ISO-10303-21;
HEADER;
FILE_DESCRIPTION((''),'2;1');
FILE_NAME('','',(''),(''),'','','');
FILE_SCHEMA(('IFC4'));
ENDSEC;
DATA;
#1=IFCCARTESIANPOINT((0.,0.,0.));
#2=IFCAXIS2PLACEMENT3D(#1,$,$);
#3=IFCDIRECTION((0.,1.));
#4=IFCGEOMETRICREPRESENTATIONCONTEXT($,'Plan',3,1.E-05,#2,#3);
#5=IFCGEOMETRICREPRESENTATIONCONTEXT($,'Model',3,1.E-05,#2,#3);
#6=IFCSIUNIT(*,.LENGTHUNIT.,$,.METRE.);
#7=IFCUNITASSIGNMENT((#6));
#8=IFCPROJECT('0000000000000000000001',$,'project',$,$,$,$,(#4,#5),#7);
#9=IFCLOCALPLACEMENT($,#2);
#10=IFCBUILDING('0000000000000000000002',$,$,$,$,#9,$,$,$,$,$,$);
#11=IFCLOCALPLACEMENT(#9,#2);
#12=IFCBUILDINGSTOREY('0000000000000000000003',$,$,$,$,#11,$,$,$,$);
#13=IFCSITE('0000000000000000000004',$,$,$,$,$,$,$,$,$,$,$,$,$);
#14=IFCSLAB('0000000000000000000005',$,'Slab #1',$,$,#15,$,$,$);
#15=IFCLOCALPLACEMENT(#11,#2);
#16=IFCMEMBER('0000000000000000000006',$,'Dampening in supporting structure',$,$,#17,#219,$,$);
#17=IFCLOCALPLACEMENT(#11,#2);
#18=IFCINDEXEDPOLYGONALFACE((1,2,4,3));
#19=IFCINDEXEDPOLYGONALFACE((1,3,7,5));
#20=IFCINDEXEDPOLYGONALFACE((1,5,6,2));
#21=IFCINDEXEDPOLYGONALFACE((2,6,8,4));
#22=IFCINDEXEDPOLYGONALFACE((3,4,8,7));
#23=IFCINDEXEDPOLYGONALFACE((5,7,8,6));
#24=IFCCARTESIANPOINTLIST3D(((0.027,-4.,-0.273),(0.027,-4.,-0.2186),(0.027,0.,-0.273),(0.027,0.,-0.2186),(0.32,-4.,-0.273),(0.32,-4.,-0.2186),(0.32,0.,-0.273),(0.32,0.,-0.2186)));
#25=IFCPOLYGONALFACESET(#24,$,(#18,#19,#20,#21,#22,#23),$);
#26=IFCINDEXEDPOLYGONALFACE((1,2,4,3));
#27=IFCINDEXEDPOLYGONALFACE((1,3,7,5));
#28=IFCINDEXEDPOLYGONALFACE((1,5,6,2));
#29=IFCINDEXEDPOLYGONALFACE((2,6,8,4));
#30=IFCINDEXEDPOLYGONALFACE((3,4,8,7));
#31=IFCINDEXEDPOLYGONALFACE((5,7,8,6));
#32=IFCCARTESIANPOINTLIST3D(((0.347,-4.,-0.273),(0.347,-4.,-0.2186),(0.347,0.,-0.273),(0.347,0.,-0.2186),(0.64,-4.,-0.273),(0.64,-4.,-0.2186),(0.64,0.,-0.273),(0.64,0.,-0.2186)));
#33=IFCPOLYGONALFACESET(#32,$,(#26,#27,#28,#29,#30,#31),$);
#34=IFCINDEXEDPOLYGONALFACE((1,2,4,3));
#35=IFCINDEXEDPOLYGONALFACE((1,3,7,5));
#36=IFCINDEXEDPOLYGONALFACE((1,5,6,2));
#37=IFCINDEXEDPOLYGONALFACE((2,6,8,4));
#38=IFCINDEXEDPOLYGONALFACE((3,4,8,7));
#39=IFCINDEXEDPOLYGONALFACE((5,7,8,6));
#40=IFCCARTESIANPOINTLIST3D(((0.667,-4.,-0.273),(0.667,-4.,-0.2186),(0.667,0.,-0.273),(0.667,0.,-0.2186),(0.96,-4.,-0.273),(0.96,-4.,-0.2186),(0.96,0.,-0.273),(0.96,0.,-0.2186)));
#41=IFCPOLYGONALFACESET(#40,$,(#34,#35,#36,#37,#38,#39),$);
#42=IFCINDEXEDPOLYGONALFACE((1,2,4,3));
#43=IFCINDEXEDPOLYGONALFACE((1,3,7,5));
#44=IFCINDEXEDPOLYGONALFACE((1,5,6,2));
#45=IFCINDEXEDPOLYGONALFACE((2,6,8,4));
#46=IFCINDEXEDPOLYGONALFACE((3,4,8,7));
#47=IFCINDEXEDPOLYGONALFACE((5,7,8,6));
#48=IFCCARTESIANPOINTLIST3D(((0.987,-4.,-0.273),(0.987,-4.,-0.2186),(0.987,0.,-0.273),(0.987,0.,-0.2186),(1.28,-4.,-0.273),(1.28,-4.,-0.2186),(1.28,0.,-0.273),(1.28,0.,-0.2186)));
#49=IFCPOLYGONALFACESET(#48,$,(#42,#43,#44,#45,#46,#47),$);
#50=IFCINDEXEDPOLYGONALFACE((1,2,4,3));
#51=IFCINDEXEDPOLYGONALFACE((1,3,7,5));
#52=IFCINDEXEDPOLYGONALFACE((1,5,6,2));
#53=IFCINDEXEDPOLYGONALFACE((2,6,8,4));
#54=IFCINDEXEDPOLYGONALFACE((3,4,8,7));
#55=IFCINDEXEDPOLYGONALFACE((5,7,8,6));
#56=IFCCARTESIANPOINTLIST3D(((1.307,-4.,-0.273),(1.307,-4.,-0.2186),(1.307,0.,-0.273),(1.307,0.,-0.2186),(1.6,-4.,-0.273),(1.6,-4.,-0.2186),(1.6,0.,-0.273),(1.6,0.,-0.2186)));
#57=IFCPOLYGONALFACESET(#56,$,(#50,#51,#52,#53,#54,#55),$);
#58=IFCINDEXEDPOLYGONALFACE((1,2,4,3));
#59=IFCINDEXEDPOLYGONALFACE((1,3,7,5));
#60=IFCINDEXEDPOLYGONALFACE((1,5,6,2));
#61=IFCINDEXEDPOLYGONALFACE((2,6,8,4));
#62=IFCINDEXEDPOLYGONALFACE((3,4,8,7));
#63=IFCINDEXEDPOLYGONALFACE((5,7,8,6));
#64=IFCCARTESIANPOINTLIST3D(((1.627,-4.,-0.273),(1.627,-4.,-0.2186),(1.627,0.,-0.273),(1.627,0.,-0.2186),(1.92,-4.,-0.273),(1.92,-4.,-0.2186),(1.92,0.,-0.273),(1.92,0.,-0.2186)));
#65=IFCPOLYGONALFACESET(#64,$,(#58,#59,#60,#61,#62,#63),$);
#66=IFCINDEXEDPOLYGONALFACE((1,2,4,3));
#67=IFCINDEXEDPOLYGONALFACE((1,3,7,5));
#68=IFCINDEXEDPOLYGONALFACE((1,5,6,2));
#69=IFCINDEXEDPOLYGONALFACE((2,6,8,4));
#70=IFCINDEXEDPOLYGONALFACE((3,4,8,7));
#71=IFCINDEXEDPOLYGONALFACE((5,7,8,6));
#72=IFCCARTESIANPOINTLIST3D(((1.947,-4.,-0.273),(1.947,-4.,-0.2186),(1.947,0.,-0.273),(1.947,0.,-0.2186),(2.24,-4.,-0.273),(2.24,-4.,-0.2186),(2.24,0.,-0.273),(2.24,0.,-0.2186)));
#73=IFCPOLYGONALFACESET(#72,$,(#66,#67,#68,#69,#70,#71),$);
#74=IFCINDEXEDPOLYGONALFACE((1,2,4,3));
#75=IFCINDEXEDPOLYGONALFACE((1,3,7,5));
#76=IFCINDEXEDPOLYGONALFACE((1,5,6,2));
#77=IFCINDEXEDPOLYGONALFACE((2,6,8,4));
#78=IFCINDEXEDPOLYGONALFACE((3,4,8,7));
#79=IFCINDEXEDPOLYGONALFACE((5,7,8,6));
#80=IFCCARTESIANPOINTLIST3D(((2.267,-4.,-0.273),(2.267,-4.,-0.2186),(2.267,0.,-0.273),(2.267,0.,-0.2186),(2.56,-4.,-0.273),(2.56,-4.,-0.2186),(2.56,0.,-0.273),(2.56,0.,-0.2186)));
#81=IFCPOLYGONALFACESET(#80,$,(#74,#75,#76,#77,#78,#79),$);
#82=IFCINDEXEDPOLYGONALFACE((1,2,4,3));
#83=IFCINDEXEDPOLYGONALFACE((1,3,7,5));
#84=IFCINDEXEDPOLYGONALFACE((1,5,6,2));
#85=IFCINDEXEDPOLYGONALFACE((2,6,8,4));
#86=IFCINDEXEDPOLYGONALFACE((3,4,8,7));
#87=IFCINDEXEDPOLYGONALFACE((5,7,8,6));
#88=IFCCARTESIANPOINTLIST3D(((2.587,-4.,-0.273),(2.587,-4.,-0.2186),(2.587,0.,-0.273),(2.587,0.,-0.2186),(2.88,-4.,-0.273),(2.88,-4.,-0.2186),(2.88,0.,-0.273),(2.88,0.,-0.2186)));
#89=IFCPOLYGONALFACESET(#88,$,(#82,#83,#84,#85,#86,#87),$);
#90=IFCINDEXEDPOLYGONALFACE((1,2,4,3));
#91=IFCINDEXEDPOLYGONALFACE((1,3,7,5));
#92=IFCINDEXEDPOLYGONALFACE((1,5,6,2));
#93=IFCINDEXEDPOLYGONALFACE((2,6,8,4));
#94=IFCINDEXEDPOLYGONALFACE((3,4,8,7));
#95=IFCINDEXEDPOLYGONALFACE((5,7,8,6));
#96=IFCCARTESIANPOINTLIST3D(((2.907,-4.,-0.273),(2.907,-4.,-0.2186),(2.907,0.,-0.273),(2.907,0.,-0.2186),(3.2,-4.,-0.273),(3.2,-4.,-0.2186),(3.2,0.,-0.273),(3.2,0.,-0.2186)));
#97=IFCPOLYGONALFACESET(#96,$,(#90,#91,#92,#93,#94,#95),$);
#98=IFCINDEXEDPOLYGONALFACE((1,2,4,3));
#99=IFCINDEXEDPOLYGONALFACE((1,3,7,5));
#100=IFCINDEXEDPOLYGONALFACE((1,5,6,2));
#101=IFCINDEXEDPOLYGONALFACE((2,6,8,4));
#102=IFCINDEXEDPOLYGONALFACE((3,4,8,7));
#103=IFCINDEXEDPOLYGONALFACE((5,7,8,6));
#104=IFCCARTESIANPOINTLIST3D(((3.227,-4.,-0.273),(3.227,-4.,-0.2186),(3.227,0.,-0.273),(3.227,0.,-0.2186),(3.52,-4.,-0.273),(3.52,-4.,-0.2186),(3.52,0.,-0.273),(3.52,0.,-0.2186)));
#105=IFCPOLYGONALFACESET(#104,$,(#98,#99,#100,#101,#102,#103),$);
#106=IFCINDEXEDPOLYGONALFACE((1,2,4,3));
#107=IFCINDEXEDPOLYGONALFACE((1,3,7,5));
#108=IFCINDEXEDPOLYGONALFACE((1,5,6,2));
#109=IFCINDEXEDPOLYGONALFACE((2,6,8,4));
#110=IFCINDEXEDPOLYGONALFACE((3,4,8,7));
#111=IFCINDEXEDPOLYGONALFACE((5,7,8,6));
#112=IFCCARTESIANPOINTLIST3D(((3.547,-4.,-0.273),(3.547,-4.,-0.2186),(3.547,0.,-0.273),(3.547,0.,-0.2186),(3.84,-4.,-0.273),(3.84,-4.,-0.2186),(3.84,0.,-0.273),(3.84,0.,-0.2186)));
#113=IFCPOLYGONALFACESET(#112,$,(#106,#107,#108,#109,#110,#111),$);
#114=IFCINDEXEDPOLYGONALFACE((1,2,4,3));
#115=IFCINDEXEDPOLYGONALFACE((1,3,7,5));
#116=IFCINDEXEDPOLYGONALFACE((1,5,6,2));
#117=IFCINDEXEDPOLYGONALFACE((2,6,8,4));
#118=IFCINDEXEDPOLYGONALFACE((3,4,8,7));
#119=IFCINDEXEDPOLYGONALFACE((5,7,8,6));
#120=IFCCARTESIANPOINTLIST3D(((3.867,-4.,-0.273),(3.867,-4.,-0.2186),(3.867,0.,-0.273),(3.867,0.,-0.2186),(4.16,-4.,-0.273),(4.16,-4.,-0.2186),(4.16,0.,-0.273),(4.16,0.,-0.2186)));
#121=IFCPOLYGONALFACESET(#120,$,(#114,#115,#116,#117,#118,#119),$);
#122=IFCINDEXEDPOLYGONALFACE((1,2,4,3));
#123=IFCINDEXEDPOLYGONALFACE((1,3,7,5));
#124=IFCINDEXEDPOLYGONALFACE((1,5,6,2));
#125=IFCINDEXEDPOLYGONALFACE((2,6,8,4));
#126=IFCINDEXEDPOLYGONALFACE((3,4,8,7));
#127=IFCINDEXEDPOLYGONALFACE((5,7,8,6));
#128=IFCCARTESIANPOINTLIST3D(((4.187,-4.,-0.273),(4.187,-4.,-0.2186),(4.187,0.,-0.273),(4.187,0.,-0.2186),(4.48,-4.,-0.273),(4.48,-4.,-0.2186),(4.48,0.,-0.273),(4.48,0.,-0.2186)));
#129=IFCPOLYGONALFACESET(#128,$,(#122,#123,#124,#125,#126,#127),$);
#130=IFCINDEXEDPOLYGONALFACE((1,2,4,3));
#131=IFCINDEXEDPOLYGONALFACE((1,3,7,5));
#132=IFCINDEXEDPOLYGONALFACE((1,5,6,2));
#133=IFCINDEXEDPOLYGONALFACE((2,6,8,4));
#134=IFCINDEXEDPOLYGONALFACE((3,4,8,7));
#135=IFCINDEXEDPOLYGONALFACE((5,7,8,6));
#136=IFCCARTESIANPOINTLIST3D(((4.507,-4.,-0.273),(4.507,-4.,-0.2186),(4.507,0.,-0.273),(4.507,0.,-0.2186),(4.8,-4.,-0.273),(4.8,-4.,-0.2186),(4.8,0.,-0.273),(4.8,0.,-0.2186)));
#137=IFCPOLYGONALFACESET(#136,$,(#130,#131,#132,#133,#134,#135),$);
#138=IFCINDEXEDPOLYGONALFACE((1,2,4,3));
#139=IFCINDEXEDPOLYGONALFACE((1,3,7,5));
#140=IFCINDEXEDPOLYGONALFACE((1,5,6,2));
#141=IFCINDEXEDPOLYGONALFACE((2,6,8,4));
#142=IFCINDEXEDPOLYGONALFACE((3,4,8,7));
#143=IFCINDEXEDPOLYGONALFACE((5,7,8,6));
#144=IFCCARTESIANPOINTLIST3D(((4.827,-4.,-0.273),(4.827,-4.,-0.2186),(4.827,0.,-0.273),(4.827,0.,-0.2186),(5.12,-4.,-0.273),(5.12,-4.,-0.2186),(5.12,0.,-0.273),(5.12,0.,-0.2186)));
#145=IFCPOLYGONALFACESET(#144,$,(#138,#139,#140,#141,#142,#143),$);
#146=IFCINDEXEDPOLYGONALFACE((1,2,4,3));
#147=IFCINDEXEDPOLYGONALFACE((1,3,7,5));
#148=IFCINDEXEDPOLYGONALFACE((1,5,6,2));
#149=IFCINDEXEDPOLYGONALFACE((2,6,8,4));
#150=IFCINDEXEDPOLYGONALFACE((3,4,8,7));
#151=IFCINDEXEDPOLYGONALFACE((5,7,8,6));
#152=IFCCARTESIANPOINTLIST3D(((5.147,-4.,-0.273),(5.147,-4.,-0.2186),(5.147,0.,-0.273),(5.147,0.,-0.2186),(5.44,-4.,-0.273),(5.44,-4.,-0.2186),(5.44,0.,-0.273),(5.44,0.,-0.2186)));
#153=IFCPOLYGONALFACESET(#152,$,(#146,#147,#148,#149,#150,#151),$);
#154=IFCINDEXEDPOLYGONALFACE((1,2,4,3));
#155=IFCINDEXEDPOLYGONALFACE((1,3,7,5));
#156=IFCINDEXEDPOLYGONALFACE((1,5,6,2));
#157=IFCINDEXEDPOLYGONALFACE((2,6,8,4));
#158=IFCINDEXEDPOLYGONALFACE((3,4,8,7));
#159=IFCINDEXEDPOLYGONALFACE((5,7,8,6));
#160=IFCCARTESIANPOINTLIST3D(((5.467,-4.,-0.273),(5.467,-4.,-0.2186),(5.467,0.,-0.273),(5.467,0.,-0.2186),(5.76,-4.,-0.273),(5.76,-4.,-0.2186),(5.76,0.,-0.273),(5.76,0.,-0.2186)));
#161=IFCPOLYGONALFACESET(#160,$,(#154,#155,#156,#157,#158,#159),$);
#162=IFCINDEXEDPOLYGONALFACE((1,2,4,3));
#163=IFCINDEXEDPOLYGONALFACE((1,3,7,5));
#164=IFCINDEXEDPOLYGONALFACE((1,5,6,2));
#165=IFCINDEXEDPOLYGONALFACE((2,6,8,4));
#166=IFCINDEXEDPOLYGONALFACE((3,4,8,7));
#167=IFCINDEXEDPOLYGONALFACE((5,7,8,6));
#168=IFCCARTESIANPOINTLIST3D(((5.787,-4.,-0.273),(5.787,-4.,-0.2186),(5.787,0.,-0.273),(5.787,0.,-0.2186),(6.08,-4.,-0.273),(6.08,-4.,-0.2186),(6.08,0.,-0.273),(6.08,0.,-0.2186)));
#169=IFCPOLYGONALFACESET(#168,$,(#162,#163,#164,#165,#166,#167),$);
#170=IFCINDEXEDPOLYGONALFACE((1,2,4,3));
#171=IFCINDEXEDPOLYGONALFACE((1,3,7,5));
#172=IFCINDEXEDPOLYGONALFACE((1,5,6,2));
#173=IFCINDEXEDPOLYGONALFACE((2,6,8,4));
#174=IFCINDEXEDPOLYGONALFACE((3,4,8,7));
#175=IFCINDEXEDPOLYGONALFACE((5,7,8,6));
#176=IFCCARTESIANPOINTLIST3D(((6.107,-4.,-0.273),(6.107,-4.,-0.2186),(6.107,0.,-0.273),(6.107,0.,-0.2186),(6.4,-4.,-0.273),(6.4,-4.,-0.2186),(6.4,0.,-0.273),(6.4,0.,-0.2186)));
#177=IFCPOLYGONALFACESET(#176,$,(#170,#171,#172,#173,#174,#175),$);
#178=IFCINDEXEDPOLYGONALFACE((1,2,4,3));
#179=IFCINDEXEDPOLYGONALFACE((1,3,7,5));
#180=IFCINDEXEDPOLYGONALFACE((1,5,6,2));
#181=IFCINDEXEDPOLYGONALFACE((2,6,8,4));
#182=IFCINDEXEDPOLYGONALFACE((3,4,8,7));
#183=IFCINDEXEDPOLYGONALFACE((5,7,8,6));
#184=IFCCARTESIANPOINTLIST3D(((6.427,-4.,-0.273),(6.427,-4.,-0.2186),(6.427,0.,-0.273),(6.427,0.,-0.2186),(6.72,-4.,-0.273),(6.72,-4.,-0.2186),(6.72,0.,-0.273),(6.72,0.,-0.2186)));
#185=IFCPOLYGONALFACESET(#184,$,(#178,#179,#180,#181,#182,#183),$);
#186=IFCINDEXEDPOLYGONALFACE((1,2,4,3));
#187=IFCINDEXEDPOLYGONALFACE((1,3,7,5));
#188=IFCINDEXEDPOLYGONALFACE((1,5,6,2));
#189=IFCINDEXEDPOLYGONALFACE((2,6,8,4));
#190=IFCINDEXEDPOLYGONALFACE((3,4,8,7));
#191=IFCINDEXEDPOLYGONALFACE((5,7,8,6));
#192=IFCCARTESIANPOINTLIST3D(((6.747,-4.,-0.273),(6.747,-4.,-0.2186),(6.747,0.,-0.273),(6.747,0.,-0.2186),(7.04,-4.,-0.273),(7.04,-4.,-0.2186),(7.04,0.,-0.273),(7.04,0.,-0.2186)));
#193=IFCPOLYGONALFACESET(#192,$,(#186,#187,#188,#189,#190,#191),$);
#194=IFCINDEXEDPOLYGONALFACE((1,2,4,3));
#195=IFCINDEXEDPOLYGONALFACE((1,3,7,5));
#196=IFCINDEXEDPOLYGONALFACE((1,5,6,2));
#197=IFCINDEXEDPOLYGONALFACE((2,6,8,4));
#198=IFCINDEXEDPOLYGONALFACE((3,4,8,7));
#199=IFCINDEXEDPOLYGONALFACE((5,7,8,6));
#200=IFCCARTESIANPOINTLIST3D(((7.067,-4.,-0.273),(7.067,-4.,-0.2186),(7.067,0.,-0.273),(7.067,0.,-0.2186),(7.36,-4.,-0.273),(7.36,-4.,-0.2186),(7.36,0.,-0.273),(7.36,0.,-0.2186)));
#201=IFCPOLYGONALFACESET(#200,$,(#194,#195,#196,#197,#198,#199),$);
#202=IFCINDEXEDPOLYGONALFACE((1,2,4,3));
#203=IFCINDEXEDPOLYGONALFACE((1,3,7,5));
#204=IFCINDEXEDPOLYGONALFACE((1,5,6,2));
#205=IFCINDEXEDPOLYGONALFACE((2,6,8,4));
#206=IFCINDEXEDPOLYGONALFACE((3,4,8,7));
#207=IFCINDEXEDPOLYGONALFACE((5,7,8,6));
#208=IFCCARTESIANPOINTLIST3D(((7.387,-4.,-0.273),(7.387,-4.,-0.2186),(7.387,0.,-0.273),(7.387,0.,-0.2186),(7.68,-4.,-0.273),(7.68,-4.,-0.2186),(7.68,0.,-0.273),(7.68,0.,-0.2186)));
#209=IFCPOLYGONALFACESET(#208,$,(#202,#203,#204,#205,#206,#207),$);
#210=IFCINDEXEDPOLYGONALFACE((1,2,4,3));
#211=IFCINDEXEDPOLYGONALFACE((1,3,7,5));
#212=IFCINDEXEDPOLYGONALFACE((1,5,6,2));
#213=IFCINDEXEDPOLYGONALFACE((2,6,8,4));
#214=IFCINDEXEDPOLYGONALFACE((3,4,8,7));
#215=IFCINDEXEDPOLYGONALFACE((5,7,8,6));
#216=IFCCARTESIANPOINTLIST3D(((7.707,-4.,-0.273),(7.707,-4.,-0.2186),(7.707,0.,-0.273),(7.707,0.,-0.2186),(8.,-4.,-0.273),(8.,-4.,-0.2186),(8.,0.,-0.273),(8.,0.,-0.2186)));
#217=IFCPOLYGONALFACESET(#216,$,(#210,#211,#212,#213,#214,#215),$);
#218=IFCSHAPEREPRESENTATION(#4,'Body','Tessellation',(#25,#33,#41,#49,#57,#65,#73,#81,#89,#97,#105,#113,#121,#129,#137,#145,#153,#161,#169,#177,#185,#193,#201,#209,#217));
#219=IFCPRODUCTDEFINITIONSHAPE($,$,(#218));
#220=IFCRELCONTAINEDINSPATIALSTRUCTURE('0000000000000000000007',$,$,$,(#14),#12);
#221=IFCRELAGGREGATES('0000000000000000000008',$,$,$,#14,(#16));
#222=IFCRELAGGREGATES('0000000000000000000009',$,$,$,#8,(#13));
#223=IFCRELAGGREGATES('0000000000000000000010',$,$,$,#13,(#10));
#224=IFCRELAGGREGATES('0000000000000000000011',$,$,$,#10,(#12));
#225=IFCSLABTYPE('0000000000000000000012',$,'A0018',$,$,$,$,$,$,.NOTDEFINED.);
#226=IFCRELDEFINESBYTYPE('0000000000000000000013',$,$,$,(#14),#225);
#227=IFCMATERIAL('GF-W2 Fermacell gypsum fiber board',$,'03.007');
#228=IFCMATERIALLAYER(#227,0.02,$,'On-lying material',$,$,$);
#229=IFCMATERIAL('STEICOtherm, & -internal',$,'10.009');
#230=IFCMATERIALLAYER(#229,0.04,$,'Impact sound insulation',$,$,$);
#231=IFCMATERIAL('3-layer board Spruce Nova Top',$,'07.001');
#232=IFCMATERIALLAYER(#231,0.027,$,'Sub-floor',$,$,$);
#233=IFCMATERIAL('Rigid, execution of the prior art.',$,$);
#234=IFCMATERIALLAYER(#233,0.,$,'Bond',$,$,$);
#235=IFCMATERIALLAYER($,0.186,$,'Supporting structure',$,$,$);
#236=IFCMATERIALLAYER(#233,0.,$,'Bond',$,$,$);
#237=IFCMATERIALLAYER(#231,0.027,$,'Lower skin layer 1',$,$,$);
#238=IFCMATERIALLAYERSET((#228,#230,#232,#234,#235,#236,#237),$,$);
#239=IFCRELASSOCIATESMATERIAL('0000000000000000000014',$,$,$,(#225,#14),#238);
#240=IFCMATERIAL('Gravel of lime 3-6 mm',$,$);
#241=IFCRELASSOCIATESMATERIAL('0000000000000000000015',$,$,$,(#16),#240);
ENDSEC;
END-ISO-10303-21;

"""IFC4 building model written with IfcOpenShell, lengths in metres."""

from ifc_helpers import new_model, si_unit, direction, frame, frame_2d, origin, place, context, project, spatial, rectangle, extrude, material, layer, layer_set, type_object, element, aggregate, save


model = new_model("IFC4")

# Units and contexts
plan_context = context("Plan", 3, precision=1e-05, world=origin(), true_north=direction((0.0, 1.0)))
model_context = context("Model", 3, precision=1e-05, world=origin(), true_north=direction((0.0, 1.0)))
ifc_project = project(units=[si_unit("LENGTHUNIT", "METRE")], contexts=[plan_context, model_context])

# Site, building, storey
site = spatial("IfcSite", under=ifc_project)
building_placement = place(None, origin())
building = spatial("IfcBuilding", under=site, at=building_placement)
storey_placement = place(building_placement, origin())
storey = spatial("IfcBuildingStorey", under=building, at=storey_placement)

# Slab, member
ifc_material_1 = material(Name="GF-W2 Fermacell gypsum fiber board", Category="03.007")
ifc_layer_1 = layer(ifc_material_1, 0.02, Name="On-lying material")
ifc_material_2 = material(Name="STEICOtherm, & -internal", Category="10.009")
ifc_layer_2 = layer(ifc_material_2, 0.04, Name="Impact sound insulation")
ifc_material_3 = material(Name="3-layer board Spruce Nova Top", Category="07.001")
ifc_layer_3 = layer(ifc_material_3, 0.027, Name="Sub-floor")
ifc_material_4 = material(Name="Rigid, execution of the prior art.")
ifc_layer_4 = layer(ifc_material_4, 0.0, Name="Bond")
ifc_layer_5 = layer(None, 0.186, Name="Supporting structure")
ifc_layer_6 = layer(ifc_material_4, 0.0, Name="Bond")
ifc_layer_7 = layer(ifc_material_3, 0.027, Name="Lower skin layer 1")
ifc_layer_set = layer_set([ifc_layer_1, ifc_layer_2, ifc_layer_3, ifc_layer_4, ifc_layer_5, ifc_layer_6, ifc_layer_7])
slab_type = type_object("IfcSlabType", Name="A0018", PredefinedType="NOTDEFINED", material=ifc_layer_set)
slab_placement = place(None, frame((0.0, 0.0, 0.0), z_axis=(0.0, 0.0, -1.0), x_axis=(1.0, 0.0, 0.0)))
slab = element("IfcSlab", 1, at=slab_placement, inside=storey, type_object=slab_type, material=ifc_layer_set, Name="Slab #1")
ifc_material_5 = material(Name="Gravel of lime 3-6 mm")
member_1_placement = place(slab_placement, origin())
member_1 = element("IfcMember", 2, at=member_1_placement, material=ifc_material_5, Name="Dampening in supporting structure", context=plan_context, shape_type="SweptSolid", body=[
    extrude(rectangle(XDim=0.293, YDim=0.0544, at=frame_2d((0.1465, 0.0272), x_axis=(1.0, 0.0))), frame((0.027, 4.0, 0.2186), z_axis=(0.0, -1.0, 0.0), x_axis=(1.0, 0.0, 0.0)), (0.0, 0.0, 1.0), 4.0),
    extrude(rectangle(XDim=0.293, YDim=0.0544, at=frame_2d((0.1465, 0.0272), x_axis=(1.0, 0.0))), frame((0.347, 4.0, 0.2186), z_axis=(0.0, -1.0, 0.0), x_axis=(1.0, 0.0, 0.0)), (0.0, 0.0, 1.0), 4.0),
    extrude(rectangle(XDim=0.293, YDim=0.0544, at=frame_2d((0.1465, 0.0272), x_axis=(1.0, 0.0))), frame((0.667, 4.0, 0.2186), z_axis=(0.0, -1.0, 0.0), x_axis=(1.0, 0.0, 0.0)), (0.0, 0.0, 1.0), 4.0),
    extrude(rectangle(XDim=0.293, YDim=0.0544, at=frame_2d((0.1465, 0.0272), x_axis=(1.0, 0.0))), frame((0.987, 4.0, 0.2186), z_axis=(0.0, -1.0, 0.0), x_axis=(1.0, 0.0, 0.0)), (0.0, 0.0, 1.0), 4.0),
    extrude(rectangle(XDim=0.293, YDim=0.0544, at=frame_2d((0.1465, 0.0272), x_axis=(1.0, 0.0))), frame((1.307, 4.0, 0.2186), z_axis=(0.0, -1.0, 0.0), x_axis=(1.0, 0.0, 0.0)), (0.0, 0.0, 1.0), 4.0),
    extrude(rectangle(XDim=0.293, YDim=0.0544, at=frame_2d((0.1465, 0.0272), x_axis=(1.0, 0.0))), frame((1.627, 4.0, 0.2186), z_axis=(0.0, -1.0, 0.0), x_axis=(1.0, 0.0, 0.0)), (0.0, 0.0, 1.0), 4.0),
    extrude(rectangle(XDim=0.293, YDim=0.0544, at=frame_2d((0.1465, 0.0272), x_axis=(1.0, 0.0))), frame((1.947, 4.0, 0.2186), z_axis=(0.0, -1.0, 0.0), x_axis=(1.0, 0.0, 0.0)), (0.0, 0.0, 1.0), 4.0),
    extrude(rectangle(XDim=0.293, YDim=0.0544, at=frame_2d((0.1465, 0.0272), x_axis=(1.0, 0.0))), frame((2.267, 4.0, 0.2186), z_axis=(0.0, -1.0, 0.0), x_axis=(1.0, 0.0, 0.0)), (0.0, 0.0, 1.0), 4.0),
    extrude(rectangle(XDim=0.293, YDim=0.0544, at=frame_2d((0.1465, 0.0272), x_axis=(1.0, 0.0))), frame((2.587, 4.0, 0.2186), z_axis=(0.0, -1.0, 0.0), x_axis=(1.0, 0.0, 0.0)), (0.0, 0.0, 1.0), 4.0),
    extrude(rectangle(XDim=0.293, YDim=0.0544, at=frame_2d((0.1465, 0.0272), x_axis=(1.0, 0.0))), frame((2.907, 4.0, 0.2186), z_axis=(0.0, -1.0, 0.0), x_axis=(1.0, 0.0, 0.0)), (0.0, 0.0, 1.0), 4.0),
    extrude(rectangle(XDim=0.293, YDim=0.0544, at=frame_2d((0.1465, 0.0272), x_axis=(1.0, 0.0))), frame((3.227, 4.0, 0.2186), z_axis=(0.0, -1.0, 0.0), x_axis=(1.0, 0.0, 0.0)), (0.0, 0.0, 1.0), 4.0),
    extrude(rectangle(XDim=0.293, YDim=0.0544, at=frame_2d((0.1465, 0.0272), x_axis=(1.0, 0.0))), frame((3.547, 4.0, 0.2186), z_axis=(0.0, -1.0, 0.0), x_axis=(1.0, 0.0, 0.0)), (0.0, 0.0, 1.0), 4.0),
    extrude(rectangle(XDim=0.293, YDim=0.0544, at=frame_2d((0.1465, 0.0272), x_axis=(1.0, 0.0))), frame((3.867, 4.0, 0.2186), z_axis=(0.0, -1.0, 0.0), x_axis=(1.0, 0.0, 0.0)), (0.0, 0.0, 1.0), 4.0),
    extrude(rectangle(XDim=0.293, YDim=0.0544, at=frame_2d((0.1465, 0.0272), x_axis=(1.0, 0.0))), frame((4.187, 4.0, 0.2186), z_axis=(0.0, -1.0, 0.0), x_axis=(1.0, 0.0, 0.0)), (0.0, 0.0, 1.0), 4.0),
    extrude(rectangle(XDim=0.293, YDim=0.0544, at=frame_2d((0.1465, 0.0272), x_axis=(1.0, 0.0))), frame((4.507, 4.0, 0.2186), z_axis=(0.0, -1.0, 0.0), x_axis=(1.0, 0.0, 0.0)), (0.0, 0.0, 1.0), 4.0),
    extrude(rectangle(XDim=0.293, YDim=0.0544, at=frame_2d((0.1465, 0.0272), x_axis=(1.0, 0.0))), frame((4.827, 4.0, 0.2186), z_axis=(0.0, -1.0, 0.0), x_axis=(1.0, 0.0, 0.0)), (0.0, 0.0, 1.0), 4.0),
    extrude(rectangle(XDim=0.293, YDim=0.0544, at=frame_2d((0.1465, 0.0272), x_axis=(1.0, 0.0))), frame((5.147, 4.0, 0.2186), z_axis=(0.0, -1.0, 0.0), x_axis=(1.0, 0.0, 0.0)), (0.0, 0.0, 1.0), 4.0),
    extrude(rectangle(XDim=0.293, YDim=0.0544, at=frame_2d((0.1465, 0.0272), x_axis=(1.0, 0.0))), frame((5.467, 4.0, 0.2186), z_axis=(0.0, -1.0, 0.0), x_axis=(1.0, 0.0, 0.0)), (0.0, 0.0, 1.0), 4.0),
    extrude(rectangle(XDim=0.293, YDim=0.0544, at=frame_2d((0.1465, 0.0272), x_axis=(1.0, 0.0))), frame((5.787, 4.0, 0.2186), z_axis=(0.0, -1.0, 0.0), x_axis=(1.0, 0.0, 0.0)), (0.0, 0.0, 1.0), 4.0),
    extrude(rectangle(XDim=0.293, YDim=0.0544, at=frame_2d((0.1465, 0.0272), x_axis=(1.0, 0.0))), frame((6.107, 4.0, 0.2186), z_axis=(0.0, -1.0, 0.0), x_axis=(1.0, 0.0, 0.0)), (0.0, 0.0, 1.0), 4.0),
    extrude(rectangle(XDim=0.293, YDim=0.0544, at=frame_2d((0.1465, 0.0272), x_axis=(1.0, 0.0))), frame((6.427, 4.0, 0.2186), z_axis=(0.0, -1.0, 0.0), x_axis=(1.0, 0.0, 0.0)), (0.0, 0.0, 1.0), 4.0),
    extrude(rectangle(XDim=0.293, YDim=0.0544, at=frame_2d((0.1465, 0.0272), x_axis=(1.0, 0.0))), frame((6.747, 4.0, 0.2186), z_axis=(0.0, -1.0, 0.0), x_axis=(1.0, 0.0, 0.0)), (0.0, 0.0, 1.0), 4.0),
    extrude(rectangle(XDim=0.293, YDim=0.0544, at=frame_2d((0.1465, 0.0272), x_axis=(1.0, 0.0))), frame((7.067, 4.0, 0.2186), z_axis=(0.0, -1.0, 0.0), x_axis=(1.0, 0.0, 0.0)), (0.0, 0.0, 1.0), 4.0),
    extrude(rectangle(XDim=0.293, YDim=0.0544, at=frame_2d((0.1465, 0.0272), x_axis=(1.0, 0.0))), frame((7.387, 4.0, 0.2186), z_axis=(0.0, -1.0, 0.0), x_axis=(1.0, 0.0, 0.0)), (0.0, 0.0, 1.0), 4.0),
    extrude(rectangle(XDim=0.293, YDim=0.0544, at=frame_2d((0.1465, 0.0272), x_axis=(1.0, 0.0))), frame((7.707, 4.0, 0.2186), z_axis=(0.0, -1.0, 0.0), x_axis=(1.0, 0.0, 0.0)), (0.0, 0.0, 1.0), 4.0),
])
aggregate(slab, [member_1])

save(model, "model.ifc")
